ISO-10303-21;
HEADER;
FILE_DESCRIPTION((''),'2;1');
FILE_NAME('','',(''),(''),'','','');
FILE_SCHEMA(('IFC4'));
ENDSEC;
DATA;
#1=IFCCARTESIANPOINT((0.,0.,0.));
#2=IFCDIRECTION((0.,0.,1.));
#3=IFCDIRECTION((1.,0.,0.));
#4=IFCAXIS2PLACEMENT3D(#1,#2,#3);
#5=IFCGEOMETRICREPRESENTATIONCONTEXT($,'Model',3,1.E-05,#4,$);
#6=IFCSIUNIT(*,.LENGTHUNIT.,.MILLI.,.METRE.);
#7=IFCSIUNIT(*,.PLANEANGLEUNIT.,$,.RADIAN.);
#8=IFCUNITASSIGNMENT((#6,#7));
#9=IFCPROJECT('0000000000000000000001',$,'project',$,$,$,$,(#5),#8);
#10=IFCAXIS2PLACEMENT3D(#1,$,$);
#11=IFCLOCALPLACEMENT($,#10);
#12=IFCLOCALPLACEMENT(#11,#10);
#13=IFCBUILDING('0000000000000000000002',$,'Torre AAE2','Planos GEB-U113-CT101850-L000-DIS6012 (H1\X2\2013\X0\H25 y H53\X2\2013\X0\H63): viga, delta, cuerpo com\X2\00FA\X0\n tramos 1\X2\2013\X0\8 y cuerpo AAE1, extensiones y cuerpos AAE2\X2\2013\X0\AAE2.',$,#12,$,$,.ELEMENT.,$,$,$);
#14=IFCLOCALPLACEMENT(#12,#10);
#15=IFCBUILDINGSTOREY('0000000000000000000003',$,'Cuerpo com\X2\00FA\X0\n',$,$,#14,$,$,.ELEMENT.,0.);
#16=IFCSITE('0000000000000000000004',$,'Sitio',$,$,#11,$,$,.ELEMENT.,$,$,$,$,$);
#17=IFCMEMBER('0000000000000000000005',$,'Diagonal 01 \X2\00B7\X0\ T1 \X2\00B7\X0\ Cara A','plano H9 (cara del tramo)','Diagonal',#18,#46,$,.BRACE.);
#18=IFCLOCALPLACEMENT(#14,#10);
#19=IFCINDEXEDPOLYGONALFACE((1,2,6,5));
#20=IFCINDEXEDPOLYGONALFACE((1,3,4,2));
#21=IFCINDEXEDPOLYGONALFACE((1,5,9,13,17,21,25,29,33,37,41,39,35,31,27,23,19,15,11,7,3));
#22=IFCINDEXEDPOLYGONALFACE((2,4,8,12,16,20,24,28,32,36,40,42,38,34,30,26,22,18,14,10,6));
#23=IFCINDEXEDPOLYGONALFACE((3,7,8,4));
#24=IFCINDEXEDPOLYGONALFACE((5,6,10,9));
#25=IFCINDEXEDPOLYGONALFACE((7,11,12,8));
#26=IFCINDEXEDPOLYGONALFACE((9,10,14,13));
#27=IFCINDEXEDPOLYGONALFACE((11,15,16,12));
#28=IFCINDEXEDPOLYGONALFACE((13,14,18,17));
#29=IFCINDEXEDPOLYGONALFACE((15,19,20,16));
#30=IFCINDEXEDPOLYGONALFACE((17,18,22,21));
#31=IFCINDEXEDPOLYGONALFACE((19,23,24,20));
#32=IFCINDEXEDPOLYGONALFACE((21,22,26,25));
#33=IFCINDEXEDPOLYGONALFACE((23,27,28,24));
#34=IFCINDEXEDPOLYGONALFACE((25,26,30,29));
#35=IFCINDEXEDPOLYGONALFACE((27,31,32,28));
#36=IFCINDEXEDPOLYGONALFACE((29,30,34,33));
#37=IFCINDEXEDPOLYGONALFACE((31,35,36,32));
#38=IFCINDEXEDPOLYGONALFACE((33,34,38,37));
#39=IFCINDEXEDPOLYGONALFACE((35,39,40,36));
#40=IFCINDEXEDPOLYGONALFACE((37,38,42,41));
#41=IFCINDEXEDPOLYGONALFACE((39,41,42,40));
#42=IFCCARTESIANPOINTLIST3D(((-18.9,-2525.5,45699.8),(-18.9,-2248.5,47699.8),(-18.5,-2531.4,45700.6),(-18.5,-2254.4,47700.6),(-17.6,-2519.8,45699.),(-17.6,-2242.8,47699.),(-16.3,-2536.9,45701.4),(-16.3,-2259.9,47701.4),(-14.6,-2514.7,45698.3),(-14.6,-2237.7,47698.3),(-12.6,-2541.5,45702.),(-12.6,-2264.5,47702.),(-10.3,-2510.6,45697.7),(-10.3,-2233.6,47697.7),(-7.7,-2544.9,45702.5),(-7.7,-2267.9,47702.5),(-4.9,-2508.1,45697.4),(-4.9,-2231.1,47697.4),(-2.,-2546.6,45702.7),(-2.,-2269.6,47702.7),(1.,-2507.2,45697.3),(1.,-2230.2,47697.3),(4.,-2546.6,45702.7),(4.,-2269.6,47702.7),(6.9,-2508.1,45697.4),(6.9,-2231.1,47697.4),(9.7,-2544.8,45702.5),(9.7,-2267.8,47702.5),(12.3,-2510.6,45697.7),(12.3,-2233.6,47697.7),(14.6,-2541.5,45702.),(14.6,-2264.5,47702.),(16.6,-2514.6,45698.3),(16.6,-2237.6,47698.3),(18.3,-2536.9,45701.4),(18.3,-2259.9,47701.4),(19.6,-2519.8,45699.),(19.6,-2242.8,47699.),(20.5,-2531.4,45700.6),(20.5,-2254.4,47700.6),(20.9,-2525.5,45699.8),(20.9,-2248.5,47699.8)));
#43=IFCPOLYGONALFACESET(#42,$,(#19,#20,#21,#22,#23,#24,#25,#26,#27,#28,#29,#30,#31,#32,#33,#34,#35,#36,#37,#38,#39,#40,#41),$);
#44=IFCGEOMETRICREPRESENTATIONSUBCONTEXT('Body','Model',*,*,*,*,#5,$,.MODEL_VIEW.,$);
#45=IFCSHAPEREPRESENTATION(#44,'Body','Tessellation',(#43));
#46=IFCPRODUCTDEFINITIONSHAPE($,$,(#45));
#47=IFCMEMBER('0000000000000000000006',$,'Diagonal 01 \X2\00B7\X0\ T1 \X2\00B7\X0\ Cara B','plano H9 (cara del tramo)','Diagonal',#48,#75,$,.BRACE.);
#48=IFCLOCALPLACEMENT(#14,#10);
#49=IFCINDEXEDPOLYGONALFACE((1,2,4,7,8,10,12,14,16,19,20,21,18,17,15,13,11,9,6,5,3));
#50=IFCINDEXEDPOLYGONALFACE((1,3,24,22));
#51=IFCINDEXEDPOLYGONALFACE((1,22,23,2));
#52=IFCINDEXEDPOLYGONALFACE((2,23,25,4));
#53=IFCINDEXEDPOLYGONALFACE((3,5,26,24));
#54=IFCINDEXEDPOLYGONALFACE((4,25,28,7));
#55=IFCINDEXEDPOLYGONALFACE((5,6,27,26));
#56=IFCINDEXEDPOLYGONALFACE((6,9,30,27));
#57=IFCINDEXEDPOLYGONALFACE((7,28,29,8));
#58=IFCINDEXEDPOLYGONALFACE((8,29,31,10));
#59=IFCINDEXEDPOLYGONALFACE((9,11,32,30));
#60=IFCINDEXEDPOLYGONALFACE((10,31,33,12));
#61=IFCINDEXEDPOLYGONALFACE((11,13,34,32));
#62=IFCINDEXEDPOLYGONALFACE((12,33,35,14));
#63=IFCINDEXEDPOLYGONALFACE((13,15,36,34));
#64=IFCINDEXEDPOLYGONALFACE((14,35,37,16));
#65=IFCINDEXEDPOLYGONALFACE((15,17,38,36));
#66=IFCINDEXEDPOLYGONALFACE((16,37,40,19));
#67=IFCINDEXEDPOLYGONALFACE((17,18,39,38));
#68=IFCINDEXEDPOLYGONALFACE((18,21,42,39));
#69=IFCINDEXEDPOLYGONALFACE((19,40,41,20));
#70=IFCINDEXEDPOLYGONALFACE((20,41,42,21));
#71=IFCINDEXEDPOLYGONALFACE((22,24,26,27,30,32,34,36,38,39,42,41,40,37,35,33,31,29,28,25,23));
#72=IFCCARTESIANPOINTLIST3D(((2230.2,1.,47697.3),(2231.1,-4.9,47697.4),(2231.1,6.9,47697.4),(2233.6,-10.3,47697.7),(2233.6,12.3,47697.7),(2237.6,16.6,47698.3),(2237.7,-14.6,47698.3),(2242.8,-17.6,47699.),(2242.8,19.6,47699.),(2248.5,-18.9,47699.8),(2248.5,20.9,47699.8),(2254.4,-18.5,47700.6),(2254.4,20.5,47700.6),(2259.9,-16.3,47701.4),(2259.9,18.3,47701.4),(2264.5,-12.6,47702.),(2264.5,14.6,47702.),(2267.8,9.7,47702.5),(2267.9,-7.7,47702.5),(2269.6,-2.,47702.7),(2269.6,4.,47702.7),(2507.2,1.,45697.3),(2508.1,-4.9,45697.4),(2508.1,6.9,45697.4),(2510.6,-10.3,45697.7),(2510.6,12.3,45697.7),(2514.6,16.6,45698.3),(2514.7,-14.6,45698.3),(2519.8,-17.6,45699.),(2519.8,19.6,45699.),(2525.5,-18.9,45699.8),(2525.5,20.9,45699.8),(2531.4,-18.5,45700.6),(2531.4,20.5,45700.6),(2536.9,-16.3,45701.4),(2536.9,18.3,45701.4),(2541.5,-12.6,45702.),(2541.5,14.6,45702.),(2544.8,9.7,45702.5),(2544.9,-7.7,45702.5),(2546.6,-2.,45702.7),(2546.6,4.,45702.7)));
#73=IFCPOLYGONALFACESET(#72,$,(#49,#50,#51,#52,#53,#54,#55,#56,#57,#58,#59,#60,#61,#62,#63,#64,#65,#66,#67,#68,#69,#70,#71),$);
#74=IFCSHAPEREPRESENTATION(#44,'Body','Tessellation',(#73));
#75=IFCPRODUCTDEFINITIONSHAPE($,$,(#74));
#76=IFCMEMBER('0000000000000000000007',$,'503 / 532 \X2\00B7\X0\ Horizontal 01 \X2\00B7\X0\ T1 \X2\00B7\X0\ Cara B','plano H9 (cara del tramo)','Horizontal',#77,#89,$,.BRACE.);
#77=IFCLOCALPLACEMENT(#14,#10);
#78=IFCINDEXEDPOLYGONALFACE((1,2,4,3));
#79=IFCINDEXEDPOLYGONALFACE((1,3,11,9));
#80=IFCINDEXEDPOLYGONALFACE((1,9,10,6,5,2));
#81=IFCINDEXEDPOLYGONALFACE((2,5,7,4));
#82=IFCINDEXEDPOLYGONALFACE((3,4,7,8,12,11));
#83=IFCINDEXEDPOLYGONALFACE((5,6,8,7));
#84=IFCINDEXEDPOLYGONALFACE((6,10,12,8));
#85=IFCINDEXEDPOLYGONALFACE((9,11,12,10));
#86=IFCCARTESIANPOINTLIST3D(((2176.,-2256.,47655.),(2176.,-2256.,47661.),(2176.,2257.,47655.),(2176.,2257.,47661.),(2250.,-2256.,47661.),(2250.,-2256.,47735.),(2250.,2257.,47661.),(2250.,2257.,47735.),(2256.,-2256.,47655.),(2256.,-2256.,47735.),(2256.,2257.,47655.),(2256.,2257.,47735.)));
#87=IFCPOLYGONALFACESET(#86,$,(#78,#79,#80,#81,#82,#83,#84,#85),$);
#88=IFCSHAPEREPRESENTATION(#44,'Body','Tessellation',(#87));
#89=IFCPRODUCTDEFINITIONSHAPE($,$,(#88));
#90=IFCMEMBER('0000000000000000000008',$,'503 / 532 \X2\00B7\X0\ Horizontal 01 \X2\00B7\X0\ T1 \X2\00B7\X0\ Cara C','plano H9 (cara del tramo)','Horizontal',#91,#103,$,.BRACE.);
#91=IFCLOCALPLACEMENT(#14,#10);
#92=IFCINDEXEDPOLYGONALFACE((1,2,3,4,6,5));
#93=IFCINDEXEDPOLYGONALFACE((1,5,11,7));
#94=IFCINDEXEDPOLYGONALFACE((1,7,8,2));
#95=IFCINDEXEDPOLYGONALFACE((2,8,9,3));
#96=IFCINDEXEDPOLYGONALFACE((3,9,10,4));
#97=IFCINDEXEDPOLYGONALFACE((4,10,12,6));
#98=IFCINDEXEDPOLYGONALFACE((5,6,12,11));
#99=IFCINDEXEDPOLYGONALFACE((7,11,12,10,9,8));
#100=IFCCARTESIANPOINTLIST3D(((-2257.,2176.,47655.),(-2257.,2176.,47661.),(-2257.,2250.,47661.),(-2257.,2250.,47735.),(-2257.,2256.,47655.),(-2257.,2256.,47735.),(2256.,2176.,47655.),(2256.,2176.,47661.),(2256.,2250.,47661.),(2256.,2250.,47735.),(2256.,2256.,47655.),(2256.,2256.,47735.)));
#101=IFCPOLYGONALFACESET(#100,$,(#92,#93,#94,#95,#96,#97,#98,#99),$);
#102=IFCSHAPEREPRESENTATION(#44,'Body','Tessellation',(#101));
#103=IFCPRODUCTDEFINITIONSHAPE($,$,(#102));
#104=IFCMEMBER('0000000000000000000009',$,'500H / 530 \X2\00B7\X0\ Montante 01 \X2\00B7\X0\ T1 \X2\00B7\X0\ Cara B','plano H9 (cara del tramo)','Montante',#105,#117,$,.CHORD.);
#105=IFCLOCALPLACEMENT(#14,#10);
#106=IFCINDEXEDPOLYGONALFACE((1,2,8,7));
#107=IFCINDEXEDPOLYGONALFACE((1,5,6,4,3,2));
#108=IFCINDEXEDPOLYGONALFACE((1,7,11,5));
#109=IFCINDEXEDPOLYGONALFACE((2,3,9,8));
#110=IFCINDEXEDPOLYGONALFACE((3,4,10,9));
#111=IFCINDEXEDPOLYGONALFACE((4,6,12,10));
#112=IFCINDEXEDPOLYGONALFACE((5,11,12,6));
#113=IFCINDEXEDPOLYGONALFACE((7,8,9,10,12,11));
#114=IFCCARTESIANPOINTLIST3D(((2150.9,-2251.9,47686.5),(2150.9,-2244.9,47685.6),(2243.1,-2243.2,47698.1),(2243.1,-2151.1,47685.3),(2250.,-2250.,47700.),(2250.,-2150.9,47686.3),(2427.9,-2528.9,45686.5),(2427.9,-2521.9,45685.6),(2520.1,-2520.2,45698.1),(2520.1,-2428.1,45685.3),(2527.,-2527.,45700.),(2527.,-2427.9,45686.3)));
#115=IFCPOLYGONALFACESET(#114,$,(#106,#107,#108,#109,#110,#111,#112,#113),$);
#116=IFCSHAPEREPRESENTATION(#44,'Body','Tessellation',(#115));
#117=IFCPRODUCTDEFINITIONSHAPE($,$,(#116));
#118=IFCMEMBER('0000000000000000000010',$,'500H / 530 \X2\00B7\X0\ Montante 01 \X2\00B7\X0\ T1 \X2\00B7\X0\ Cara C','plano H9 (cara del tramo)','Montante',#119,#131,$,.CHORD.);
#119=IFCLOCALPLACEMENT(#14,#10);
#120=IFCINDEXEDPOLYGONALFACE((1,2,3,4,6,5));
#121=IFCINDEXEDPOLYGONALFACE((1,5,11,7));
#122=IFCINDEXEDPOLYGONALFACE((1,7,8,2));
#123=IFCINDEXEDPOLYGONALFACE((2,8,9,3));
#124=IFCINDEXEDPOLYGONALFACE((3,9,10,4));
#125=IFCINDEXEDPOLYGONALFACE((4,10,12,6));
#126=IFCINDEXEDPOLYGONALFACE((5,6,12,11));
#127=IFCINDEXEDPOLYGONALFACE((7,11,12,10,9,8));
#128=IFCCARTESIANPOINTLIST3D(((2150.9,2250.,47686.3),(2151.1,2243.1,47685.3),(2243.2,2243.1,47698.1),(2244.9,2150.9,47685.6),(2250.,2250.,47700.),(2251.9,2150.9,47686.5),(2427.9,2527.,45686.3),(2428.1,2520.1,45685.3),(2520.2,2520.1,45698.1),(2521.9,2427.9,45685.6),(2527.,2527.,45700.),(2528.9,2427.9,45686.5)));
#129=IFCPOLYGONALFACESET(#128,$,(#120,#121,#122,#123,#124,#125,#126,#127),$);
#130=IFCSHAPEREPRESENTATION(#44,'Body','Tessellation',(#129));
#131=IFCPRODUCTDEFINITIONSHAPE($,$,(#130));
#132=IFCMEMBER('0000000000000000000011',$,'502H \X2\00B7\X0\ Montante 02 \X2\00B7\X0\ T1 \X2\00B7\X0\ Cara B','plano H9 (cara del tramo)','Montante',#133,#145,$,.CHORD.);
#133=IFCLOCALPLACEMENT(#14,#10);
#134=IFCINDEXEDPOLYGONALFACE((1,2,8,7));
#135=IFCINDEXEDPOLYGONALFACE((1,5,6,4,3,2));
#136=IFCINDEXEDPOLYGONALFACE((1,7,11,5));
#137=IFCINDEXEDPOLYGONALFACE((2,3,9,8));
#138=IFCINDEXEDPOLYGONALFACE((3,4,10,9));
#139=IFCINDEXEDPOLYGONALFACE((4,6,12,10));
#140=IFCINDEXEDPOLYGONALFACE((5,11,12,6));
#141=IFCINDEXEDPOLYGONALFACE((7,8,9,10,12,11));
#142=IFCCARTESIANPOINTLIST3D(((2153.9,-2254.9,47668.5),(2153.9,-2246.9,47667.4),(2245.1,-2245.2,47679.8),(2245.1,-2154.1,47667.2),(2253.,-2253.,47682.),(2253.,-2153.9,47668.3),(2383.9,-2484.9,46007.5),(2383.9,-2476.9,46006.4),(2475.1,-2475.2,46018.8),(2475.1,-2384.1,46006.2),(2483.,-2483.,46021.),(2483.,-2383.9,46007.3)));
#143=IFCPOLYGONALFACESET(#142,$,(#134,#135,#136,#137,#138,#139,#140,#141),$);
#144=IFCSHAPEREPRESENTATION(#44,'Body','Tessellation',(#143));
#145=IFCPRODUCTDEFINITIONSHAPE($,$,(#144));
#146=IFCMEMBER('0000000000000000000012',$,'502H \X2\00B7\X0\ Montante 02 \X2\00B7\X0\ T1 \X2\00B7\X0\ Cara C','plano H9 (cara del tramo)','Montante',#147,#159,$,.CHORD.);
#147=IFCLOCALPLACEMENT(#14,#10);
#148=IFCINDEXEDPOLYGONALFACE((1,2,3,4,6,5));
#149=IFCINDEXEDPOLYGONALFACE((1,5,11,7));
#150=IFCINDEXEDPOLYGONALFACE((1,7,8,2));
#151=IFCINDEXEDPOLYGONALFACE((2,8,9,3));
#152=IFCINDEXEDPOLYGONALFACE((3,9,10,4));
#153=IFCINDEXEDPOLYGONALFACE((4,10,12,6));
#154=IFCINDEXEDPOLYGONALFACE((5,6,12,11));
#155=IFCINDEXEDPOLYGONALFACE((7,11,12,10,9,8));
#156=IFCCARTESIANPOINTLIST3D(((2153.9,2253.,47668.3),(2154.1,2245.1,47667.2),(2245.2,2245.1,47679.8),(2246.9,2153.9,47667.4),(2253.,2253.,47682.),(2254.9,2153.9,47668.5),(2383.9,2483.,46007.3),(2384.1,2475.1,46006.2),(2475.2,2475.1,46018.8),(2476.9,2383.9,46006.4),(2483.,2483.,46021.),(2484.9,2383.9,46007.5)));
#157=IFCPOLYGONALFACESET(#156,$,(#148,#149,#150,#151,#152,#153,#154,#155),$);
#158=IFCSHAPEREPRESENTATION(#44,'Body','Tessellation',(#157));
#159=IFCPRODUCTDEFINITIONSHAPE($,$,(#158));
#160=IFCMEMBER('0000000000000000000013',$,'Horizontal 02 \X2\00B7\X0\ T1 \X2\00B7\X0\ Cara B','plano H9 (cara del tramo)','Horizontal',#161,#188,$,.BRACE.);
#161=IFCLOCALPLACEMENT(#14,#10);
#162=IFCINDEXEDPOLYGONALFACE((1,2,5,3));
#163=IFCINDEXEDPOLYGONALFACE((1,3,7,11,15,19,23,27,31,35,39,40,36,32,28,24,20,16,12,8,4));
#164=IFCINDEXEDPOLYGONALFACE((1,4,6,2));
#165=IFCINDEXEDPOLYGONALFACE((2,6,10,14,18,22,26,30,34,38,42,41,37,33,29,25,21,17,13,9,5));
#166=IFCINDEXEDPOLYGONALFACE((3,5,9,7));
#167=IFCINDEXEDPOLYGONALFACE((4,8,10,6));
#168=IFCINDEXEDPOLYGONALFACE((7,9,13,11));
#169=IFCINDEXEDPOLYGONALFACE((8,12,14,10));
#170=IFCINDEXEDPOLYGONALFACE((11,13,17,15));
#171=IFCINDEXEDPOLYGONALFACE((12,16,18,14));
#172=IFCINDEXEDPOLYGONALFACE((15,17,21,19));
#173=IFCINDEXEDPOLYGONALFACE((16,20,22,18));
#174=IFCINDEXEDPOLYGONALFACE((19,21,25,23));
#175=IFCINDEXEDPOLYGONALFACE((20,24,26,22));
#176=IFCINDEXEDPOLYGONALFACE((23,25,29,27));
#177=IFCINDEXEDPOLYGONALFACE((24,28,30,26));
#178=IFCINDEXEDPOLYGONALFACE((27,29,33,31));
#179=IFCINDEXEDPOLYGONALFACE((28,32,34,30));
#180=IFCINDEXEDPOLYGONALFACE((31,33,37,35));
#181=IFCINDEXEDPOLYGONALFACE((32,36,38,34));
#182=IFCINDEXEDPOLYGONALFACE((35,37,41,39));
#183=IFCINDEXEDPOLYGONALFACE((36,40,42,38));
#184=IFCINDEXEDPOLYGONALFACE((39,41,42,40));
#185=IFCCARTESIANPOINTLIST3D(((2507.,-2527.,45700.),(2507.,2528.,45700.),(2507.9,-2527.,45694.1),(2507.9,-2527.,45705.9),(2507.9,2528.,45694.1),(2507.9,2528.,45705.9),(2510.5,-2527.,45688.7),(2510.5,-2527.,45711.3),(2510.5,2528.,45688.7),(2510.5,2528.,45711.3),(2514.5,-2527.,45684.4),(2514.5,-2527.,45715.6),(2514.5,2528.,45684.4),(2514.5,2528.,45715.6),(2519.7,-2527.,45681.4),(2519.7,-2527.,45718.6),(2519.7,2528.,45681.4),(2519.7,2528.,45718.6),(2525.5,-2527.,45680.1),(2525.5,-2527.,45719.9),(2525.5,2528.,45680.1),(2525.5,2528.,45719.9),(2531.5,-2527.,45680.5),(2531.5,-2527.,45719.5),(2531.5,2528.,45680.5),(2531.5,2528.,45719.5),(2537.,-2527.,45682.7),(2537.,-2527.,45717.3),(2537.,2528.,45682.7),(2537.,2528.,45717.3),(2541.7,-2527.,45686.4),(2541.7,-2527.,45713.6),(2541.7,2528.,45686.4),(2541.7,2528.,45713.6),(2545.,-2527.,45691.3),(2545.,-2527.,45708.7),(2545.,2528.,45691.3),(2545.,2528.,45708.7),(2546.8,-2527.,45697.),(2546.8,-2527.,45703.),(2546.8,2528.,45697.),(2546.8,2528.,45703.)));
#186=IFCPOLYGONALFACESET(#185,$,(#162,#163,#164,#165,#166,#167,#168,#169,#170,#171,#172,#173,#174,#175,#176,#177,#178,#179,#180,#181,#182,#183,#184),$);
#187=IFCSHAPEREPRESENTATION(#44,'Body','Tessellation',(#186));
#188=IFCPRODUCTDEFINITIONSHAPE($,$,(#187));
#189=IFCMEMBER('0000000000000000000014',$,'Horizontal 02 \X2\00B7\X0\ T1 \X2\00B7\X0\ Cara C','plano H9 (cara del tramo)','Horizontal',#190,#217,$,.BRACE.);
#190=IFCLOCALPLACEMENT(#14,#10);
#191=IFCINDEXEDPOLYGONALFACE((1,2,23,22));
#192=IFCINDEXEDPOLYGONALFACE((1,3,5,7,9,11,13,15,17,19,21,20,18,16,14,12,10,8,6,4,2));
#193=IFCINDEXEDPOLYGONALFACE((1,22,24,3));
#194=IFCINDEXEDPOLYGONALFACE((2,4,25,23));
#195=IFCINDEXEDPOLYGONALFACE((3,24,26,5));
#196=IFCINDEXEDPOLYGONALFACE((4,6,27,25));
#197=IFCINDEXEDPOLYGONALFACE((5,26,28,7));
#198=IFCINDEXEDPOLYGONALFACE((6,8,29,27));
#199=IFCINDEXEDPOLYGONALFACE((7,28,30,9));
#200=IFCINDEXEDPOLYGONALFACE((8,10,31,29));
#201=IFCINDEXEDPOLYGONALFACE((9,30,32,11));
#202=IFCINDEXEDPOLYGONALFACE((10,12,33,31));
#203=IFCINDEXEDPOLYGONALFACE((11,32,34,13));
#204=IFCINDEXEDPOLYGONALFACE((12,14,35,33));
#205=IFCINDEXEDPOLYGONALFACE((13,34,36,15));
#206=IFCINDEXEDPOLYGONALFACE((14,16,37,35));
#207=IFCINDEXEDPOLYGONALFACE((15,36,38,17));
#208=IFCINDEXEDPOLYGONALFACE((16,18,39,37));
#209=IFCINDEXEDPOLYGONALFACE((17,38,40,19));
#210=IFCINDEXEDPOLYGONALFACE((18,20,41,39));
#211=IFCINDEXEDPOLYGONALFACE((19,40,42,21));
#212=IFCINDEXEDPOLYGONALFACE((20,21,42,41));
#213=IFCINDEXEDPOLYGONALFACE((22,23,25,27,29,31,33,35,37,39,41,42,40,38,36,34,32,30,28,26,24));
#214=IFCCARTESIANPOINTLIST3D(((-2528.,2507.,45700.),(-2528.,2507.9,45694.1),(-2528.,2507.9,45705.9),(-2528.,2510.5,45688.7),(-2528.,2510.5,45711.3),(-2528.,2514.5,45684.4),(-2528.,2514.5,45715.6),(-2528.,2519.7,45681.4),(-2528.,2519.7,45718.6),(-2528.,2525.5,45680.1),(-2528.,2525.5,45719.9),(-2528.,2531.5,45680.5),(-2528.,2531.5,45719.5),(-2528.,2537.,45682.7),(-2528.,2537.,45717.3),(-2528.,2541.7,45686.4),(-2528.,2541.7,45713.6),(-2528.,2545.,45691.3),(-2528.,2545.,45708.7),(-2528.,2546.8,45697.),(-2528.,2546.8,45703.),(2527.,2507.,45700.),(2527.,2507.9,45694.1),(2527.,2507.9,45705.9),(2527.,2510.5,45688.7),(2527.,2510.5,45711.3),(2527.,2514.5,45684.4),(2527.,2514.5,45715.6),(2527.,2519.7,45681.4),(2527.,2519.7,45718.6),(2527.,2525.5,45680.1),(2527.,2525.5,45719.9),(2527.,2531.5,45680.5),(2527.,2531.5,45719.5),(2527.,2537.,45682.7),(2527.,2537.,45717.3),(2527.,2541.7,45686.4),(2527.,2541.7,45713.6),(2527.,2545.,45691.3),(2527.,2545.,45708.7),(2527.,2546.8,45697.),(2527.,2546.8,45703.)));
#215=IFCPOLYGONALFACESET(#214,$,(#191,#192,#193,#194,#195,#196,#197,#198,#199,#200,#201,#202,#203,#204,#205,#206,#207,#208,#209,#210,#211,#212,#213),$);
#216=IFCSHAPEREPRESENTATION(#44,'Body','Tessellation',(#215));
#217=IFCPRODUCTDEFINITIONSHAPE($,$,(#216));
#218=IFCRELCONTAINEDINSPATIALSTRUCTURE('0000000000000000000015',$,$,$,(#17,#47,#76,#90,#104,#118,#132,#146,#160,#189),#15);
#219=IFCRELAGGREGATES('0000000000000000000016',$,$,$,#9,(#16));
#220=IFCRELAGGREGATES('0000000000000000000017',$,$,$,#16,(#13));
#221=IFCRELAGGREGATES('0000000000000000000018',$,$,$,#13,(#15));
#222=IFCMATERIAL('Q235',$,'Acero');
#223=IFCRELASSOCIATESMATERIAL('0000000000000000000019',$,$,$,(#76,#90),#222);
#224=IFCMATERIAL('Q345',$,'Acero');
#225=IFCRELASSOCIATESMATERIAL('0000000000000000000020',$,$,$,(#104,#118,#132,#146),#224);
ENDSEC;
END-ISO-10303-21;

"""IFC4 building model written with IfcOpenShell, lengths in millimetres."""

from ifc_helpers import new_model, si_unit, frame, frame_2d, origin, origin_with_axes, place, context, subcontext, project, spatial, circle, l_section, extrude, material, element, save


model = new_model("IFC4")

# Units and contexts
model_context = context("Model", 3, precision=1e-05, world=origin_with_axes())
body_context = subcontext(model_context, "Body", "Model", "MODEL_VIEW")
ifc_project = project(units=[si_unit("LENGTHUNIT", "METRE", prefix="MILLI"), si_unit("PLANEANGLEUNIT", "RADIAN")], contexts=[model_context])

# Site, building, storey
site_placement = place(None, origin())
site = spatial("IfcSite", under=ifc_project, at=site_placement, Name="Sitio", CompositionType="ELEMENT")
building_placement = place(site_placement, origin())
building = spatial("IfcBuilding", under=site, at=building_placement, Name="Torre AAE2", Description="Planos GEB-U113-CT101850-L000-DIS6012 (H1–H25 y H53–H63): viga, delta, cuerpo común tramos 1–8 y cuerpo AAE1, extensiones y cuerpos AAE2–AAE2.", CompositionType="ELEMENT")
storey_placement = place(building_placement, origin())
storey = spatial("IfcBuildingStorey", under=building, at=storey_placement, Name="Cuerpo común", CompositionType="ELEMENT", Elevation=0.0)

# Members
for number, where, z_axis, x_axis, name in (
    (1, (1.0, -2527.0, 45700.0), (0.0, 0.13719, 0.990545), (-0.000423, 0.990545, -0.13719), "Diagonal 01 · T1 · Cara A"),
    (2, (2527.0, 1.0, 45700.0), (-0.13719, 0.0, 0.990545), (-0.990545, -0.000423, -0.13719), "Diagonal 01 · T1 · Cara B"),
):
    element("IfcMember", number, at=place(storey_placement, frame(where, z_axis=z_axis, x_axis=x_axis)), inside=storey, Name=name, Description="plano H9 (cara del tramo)", ObjectType="Diagonal", PredefinedType="BRACE", context=body_context, shape_type="SweptSolid", body=[
        extrude(circle(Radius=20.0), None, (0.0, 0.0, 1.0), 2019.1),
    ])
ifc_material_1 = material(Name="Q235", Category="Acero")
for number, where, z_axis, x_axis, name in (
    (3, (2256.0, -2256.0, 47655.0), (0.0, 1.0, 0.0), (-1.0, 0.0, 0.0), "503 / 532 · Horizontal 01 · T1 · Cara B"),
    (4, (2256.0, 2256.0, 47655.0), (-1.0, 0.0, 0.0), (0.0, -1.0, 0.0), "503 / 532 · Horizontal 01 · T1 · Cara C"),
):
    element("IfcMember", number, at=place(storey_placement, frame(where, z_axis=z_axis, x_axis=x_axis)), inside=storey, material=ifc_material_1, Name=name, Description="plano H9 (cara del tramo)", ObjectType="Horizontal", PredefinedType="BRACE", context=body_context, shape_type="SweptSolid", body=[
        extrude(l_section(Depth=80.0, Width=80.0, Thickness=6.0, at=frame_2d((40.0, 40.0))), None, (0.0, 0.0, 1.0), 4513.0),
    ])
ifc_material_2 = material(Name="Q345", Category="Acero")
for number, where, z_axis, x_axis, name in (
    (5, (2250.0, -2250.0, 47700.0), (0.135917, -0.135917, -0.981353), (-0.99072, -0.018647, -0.134632), "500H / 530 · Montante 01 · T1 · Cara B"),
    (6, (2250.0, 2250.0, 47700.0), (0.135917, 0.135917, -0.981353), (0.018647, -0.99072, -0.134632), "500H / 530 · Montante 01 · T1 · Cara C"),
):
    element("IfcMember", number, at=place(storey_placement, frame(where, z_axis=z_axis, x_axis=x_axis)), inside=storey, material=ifc_material_2, Name=name, Description="plano H9 (cara del tramo)", ObjectType="Montante", PredefinedType="CHORD", context=body_context, shape_type="SweptSolid", body=[
        extrude(l_section(Depth=100.0, Width=100.0, Thickness=7.0, at=frame_2d((50.0, 50.0))), None, (0.0, 0.0, 1.0), 2038.0),
    ])
for number, where, z_axis, x_axis, name in (
    (7, (2253.0, -2253.0, 47682.0), (0.13589, -0.13589, -0.98136), (-0.990724, -0.018639, -0.134605), "502H · Montante 02 · T1 · Cara B"),
    (8, (2253.0, 2253.0, 47682.0), (0.13589, 0.13589, -0.98136), (0.018639, -0.990724, -0.134605), "502H · Montante 02 · T1 · Cara C"),
):
    element("IfcMember", number, at=place(storey_placement, frame(where, z_axis=z_axis, x_axis=x_axis)), inside=storey, material=ifc_material_2, Name=name, Description="plano H9 (cara del tramo)", ObjectType="Montante", PredefinedType="CHORD", context=body_context, shape_type="SweptSolid", body=[
        extrude(l_section(Depth=100.0, Width=100.0, Thickness=8.0, at=frame_2d((50.0, 50.0))), None, (0.0, 0.0, 1.0), 1692.5),
    ])
for number, where, z_axis, x_axis, name in (
    (9, (2527.0, -2527.0, 45700.0), (0.0, 1.0, 0.0), (-1.0, 0.0, 0.0), "Horizontal 02 · T1 · Cara B"),
    (10, (2527.0, 2527.0, 45700.0), (-1.0, 0.0, 0.0), (0.0, -1.0, 0.0), "Horizontal 02 · T1 · Cara C"),
):
    element("IfcMember", number, at=place(storey_placement, frame(where, z_axis=z_axis, x_axis=x_axis)), inside=storey, Name=name, Description="plano H9 (cara del tramo)", ObjectType="Horizontal", PredefinedType="BRACE", context=body_context, shape_type="SweptSolid", body=[
        extrude(circle(Radius=20.0), None, (0.0, 0.0, 1.0), 5055.0),
    ])

save(model, "model.ifc")
